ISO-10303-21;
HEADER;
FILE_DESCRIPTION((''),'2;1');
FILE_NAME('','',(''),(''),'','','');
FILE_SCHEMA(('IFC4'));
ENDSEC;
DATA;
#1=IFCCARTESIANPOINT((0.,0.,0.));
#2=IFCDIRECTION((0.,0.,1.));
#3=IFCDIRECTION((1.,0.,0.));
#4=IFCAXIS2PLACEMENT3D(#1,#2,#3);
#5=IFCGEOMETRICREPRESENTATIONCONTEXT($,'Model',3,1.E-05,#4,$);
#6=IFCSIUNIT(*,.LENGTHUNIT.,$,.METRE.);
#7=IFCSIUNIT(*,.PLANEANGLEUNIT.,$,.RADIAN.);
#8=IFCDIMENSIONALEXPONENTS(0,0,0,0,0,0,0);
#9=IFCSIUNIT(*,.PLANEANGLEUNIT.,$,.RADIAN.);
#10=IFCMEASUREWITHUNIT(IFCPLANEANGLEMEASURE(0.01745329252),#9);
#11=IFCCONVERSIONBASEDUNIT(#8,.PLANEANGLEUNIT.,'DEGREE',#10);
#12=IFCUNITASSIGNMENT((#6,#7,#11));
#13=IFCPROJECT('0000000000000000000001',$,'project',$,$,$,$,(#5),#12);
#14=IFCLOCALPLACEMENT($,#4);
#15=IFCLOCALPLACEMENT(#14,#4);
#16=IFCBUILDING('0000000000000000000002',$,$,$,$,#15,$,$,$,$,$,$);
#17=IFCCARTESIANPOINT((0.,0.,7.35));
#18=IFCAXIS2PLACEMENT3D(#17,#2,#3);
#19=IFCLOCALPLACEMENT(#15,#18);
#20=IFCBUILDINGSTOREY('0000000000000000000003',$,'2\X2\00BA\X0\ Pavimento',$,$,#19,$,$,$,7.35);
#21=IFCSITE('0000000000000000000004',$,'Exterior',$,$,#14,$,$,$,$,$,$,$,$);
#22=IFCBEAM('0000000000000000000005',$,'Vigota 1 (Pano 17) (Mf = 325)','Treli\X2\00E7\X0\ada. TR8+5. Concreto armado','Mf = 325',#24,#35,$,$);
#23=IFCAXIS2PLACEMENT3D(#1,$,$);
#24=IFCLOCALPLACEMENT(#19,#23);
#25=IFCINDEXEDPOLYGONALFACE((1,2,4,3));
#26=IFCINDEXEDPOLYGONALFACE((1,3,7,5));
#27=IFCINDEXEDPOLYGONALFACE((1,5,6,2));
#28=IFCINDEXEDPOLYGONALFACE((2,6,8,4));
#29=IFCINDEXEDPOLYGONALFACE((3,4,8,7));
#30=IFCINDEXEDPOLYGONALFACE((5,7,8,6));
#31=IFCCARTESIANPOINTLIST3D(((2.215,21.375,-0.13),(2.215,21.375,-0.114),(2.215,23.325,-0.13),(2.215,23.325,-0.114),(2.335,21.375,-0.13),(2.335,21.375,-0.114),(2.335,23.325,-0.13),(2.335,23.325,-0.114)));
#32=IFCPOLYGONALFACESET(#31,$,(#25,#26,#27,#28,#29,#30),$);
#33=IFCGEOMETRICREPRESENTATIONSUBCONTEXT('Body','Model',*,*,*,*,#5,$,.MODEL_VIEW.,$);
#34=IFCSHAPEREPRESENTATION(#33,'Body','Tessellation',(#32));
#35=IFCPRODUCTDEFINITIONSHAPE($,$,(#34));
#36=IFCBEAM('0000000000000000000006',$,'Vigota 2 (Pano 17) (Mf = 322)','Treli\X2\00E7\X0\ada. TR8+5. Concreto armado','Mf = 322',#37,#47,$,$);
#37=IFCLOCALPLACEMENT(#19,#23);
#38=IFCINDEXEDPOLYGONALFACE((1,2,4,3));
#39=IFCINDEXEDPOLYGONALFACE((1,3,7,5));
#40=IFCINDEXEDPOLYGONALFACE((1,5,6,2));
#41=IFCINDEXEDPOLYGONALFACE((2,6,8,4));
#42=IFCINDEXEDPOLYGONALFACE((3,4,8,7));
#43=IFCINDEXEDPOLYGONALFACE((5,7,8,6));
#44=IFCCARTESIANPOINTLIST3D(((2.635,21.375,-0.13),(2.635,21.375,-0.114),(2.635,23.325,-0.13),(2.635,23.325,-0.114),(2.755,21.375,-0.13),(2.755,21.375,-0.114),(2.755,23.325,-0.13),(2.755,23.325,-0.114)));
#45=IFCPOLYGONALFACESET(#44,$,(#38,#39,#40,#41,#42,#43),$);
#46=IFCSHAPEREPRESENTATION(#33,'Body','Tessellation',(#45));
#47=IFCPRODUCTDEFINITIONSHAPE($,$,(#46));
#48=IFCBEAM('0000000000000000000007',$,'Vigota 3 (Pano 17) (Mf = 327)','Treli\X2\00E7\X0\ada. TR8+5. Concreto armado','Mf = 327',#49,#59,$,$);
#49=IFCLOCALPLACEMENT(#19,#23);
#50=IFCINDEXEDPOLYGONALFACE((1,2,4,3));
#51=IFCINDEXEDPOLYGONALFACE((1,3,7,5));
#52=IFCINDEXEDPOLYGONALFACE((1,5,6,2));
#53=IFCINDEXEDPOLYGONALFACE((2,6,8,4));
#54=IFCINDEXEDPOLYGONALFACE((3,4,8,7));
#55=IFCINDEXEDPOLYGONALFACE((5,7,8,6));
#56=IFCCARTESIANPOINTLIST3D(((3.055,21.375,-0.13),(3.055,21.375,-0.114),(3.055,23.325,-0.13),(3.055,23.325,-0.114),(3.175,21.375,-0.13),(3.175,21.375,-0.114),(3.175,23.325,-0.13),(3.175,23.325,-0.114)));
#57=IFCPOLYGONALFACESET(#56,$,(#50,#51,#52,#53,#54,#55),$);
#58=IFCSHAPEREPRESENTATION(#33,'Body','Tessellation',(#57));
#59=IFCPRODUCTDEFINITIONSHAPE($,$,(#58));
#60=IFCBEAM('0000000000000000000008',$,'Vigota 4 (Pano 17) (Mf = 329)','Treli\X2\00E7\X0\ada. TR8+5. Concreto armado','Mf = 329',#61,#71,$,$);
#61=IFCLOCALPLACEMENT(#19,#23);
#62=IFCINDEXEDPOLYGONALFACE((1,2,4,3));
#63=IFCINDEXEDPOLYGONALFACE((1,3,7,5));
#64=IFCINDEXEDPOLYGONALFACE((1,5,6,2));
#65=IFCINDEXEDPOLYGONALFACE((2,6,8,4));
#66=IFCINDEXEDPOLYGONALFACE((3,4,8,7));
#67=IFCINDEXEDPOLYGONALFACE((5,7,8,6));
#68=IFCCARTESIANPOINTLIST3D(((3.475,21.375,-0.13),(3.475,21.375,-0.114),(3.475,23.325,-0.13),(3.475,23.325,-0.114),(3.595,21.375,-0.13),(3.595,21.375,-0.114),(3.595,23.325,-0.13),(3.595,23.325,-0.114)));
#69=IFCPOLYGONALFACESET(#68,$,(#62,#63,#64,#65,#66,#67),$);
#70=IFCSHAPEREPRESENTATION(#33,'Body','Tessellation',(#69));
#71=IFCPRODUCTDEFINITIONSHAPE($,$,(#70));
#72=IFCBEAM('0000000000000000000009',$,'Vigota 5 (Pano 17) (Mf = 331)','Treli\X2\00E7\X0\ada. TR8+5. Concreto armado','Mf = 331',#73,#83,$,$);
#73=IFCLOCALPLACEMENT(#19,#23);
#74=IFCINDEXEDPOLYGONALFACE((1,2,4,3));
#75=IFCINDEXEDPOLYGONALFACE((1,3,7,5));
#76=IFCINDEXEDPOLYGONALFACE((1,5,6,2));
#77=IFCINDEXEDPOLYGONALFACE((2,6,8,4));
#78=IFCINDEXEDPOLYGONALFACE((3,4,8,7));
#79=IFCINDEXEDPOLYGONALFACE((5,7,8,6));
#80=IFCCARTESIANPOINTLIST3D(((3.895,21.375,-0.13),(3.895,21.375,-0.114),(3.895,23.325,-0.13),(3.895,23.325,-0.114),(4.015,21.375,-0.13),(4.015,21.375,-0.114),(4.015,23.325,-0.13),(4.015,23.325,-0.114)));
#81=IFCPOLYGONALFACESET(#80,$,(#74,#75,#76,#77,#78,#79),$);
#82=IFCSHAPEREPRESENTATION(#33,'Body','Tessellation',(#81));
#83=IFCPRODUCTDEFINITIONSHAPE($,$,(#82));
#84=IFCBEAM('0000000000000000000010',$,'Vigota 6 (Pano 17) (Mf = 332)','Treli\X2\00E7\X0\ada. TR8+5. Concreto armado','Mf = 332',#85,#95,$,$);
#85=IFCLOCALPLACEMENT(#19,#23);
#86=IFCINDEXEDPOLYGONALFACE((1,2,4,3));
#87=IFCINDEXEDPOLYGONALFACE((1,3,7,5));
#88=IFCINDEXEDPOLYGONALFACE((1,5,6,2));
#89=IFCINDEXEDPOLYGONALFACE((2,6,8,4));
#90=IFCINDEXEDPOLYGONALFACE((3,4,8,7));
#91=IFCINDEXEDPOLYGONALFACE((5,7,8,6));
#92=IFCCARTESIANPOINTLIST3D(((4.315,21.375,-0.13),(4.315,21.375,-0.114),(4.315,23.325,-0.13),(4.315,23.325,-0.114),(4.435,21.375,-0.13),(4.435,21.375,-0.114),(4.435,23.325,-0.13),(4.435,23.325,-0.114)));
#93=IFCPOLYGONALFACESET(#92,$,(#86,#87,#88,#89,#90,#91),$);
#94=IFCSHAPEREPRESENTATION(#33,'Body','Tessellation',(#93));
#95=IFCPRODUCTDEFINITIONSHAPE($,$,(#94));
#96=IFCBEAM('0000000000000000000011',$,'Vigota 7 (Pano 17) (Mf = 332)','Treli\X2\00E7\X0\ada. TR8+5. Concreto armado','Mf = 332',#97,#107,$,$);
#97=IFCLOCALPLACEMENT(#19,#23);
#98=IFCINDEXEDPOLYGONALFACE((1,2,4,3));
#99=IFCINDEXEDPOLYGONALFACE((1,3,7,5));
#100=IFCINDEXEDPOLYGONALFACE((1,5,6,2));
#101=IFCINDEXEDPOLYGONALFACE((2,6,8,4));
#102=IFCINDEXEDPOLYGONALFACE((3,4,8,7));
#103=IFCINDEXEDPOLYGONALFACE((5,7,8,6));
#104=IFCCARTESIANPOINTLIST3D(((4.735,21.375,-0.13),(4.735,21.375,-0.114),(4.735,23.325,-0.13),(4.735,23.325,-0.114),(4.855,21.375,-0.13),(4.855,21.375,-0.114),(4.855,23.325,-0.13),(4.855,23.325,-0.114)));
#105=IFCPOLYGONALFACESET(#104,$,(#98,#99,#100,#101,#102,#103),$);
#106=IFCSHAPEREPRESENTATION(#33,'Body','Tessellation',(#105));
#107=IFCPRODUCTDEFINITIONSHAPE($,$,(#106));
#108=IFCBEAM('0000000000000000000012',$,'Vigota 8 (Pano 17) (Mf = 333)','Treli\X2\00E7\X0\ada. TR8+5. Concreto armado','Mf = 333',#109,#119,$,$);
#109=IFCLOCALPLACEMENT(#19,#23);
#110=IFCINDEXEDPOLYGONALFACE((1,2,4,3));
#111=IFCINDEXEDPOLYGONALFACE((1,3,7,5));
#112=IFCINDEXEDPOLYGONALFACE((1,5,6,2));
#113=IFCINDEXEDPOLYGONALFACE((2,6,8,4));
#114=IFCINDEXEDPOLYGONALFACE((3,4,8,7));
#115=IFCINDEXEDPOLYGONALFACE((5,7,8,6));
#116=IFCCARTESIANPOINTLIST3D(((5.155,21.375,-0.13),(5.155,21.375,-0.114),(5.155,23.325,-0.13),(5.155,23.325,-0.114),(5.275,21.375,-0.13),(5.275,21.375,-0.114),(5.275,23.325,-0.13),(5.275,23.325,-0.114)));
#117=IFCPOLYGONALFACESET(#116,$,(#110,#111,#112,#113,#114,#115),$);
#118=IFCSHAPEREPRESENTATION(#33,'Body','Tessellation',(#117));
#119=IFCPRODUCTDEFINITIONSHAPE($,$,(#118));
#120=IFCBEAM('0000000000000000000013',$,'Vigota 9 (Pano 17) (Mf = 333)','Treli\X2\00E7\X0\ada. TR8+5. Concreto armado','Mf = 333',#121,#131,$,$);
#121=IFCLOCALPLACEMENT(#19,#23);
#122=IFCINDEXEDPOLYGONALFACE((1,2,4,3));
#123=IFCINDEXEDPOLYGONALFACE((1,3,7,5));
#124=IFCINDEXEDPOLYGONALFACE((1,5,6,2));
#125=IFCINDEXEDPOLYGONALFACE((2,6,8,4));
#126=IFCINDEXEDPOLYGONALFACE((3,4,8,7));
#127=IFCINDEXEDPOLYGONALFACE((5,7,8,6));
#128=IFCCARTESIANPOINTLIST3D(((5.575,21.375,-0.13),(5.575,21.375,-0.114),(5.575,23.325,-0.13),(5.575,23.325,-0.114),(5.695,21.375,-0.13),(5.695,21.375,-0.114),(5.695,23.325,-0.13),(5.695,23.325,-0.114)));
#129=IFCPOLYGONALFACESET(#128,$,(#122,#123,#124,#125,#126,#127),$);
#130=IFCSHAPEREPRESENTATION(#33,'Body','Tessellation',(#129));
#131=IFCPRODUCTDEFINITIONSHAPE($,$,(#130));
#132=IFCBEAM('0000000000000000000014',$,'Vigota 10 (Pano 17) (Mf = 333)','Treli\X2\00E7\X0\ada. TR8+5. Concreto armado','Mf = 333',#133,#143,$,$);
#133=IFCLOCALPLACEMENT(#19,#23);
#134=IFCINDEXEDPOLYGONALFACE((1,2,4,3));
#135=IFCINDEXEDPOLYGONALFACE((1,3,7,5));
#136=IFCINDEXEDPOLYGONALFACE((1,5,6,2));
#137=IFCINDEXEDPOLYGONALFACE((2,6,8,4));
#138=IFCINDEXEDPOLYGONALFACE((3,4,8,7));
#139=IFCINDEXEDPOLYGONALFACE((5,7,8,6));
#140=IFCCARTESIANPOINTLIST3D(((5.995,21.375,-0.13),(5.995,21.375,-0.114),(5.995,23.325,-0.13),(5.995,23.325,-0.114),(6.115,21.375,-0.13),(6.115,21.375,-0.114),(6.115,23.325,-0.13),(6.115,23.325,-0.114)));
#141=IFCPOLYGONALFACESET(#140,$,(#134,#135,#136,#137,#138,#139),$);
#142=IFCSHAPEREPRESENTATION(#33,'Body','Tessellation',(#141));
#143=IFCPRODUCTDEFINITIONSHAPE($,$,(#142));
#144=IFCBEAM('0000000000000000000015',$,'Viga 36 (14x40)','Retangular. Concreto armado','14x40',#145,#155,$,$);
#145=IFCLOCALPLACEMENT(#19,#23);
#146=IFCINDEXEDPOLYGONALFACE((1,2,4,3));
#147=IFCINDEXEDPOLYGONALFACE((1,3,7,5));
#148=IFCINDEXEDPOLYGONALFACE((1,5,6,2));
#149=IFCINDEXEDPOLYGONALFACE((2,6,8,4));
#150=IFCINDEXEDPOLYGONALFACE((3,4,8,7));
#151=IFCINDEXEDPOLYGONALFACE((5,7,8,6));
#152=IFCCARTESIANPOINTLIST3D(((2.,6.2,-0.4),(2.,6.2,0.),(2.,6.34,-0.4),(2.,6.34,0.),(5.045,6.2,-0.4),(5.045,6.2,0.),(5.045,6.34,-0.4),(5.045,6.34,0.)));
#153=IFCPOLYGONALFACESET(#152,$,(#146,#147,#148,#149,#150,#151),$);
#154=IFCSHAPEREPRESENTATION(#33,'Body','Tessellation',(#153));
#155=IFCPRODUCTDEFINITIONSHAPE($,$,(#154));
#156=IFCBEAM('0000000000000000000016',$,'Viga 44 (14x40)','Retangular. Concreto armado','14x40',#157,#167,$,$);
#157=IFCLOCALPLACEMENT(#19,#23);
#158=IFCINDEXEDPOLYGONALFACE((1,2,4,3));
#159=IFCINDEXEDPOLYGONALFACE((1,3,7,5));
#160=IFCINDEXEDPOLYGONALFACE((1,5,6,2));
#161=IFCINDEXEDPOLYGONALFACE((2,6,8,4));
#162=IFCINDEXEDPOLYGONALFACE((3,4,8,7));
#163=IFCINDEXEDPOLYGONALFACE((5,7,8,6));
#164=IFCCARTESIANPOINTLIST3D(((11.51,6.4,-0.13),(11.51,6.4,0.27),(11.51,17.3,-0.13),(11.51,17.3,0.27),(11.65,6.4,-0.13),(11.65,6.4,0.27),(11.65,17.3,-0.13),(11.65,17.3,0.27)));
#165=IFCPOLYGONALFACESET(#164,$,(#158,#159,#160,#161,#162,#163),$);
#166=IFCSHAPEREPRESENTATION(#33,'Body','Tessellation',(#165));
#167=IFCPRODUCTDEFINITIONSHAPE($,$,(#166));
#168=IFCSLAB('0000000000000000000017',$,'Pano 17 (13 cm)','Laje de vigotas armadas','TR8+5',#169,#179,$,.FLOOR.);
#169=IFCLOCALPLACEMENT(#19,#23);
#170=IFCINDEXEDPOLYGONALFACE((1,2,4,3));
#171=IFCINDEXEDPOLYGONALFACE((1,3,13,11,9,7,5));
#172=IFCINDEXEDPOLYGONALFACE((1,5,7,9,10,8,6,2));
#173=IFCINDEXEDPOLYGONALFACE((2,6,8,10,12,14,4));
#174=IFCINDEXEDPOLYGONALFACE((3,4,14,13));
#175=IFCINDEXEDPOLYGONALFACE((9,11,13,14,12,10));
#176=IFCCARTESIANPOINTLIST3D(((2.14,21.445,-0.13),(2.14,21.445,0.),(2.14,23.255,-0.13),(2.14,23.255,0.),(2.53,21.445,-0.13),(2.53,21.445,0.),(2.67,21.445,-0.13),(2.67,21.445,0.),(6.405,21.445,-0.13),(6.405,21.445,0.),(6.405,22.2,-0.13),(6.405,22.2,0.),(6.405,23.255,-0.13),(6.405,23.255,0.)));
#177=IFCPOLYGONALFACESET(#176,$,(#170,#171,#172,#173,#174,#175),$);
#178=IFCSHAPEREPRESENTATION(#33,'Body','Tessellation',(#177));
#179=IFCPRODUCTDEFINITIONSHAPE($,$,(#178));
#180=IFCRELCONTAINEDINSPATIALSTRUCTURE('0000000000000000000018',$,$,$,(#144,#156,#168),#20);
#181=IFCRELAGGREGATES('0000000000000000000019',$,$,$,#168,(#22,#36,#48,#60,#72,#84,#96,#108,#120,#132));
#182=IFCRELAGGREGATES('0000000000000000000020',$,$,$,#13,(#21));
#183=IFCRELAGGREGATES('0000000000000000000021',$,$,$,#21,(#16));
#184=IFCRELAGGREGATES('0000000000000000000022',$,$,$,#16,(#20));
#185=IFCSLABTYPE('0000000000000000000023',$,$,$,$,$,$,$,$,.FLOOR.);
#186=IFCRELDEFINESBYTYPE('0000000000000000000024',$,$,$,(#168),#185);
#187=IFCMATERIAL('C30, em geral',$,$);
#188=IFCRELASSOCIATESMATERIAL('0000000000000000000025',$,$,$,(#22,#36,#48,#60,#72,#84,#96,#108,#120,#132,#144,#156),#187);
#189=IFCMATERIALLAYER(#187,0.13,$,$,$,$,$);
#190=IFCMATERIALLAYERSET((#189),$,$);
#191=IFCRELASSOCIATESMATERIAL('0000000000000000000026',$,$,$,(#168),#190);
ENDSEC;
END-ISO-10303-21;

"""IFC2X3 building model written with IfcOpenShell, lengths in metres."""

from ifc_helpers import new_model, entity, si_unit, converted_unit, frame, frame_2d, origin_with_axes, place, context, subcontext, project, spatial, polyline, rectangle, outline, extrude, material, layer, layer_set, layer_usage, type_object, element, aggregate, save


model = new_model("IFC2X3")

# Units and contexts
model_context = context("Model", 3, precision=1e-05, world=origin_with_axes())
body_context = subcontext(model_context, "Body", "Model", "MODEL_VIEW")
ifc_project = project(units=[si_unit("LENGTHUNIT", "METRE"), si_unit("PLANEANGLEUNIT", "RADIAN"), converted_unit("PLANEANGLEUNIT", "DEGREE", entity("IfcPlaneAngleMeasure", 0.01745329252), si_unit("PLANEANGLEUNIT", "RADIAN"), dimensions=[0, 0, 0, 0, 0, 0, 0])], contexts=[model_context])

# Beams
ifc_material = material(Name="C30, em geral")
site_placement = place(None, origin_with_axes())
building_placement = place(site_placement, origin_with_axes())
storey_placement = place(building_placement, frame((0.0, 0.0, 7.35), z_axis=(0.0, 0.0, 1.0), x_axis=(1.0, 0.0, 0.0)))
beam_1_placement = place(storey_placement, frame((2.275, 21.375, -0.122), z_axis=(0.0, 1.0, 0.0), x_axis=(-1.0, 0.0, 0.0)))
beam_1 = element("IfcBeam", 1, at=beam_1_placement, material=ifc_material, Name="Vigota 1 (Pano 17) (Mf = 325)", Description="Treliçada. TR8+5. Concreto armado", ObjectType="Mf = 325", context=body_context, shape_type="SweptSolid", body=[
    extrude(outline(polyline([(0.06, 0.008), (-0.06, 0.008), (-0.06, -0.008), (0.06, -0.008), (0.06, 0.008)])), origin_with_axes(), (0.0, 0.0, 1.0), 1.95),
])
beam_2_placement = place(storey_placement, frame((2.695, 21.375, -0.122), z_axis=(0.0, 1.0, 0.0), x_axis=(-1.0, 0.0, 0.0)))
beam_2 = element("IfcBeam", 2, at=beam_2_placement, material=ifc_material, Name="Vigota 2 (Pano 17) (Mf = 322)", Description="Treliçada. TR8+5. Concreto armado", ObjectType="Mf = 322", context=body_context, shape_type="SweptSolid", body=[
    extrude(outline(polyline([(0.06, 0.008), (-0.06, 0.008), (-0.06, -0.008), (0.06, -0.008), (0.06, 0.008)])), origin_with_axes(), (0.0, 0.0, 1.0), 1.95),
])
beam_3_placement = place(storey_placement, frame((3.115, 21.375, -0.122), z_axis=(0.0, 1.0, 0.0), x_axis=(-1.0, 0.0, 0.0)))
beam_3 = element("IfcBeam", 3, at=beam_3_placement, material=ifc_material, Name="Vigota 3 (Pano 17) (Mf = 327)", Description="Treliçada. TR8+5. Concreto armado", ObjectType="Mf = 327", context=body_context, shape_type="SweptSolid", body=[
    extrude(outline(polyline([(0.06, 0.008), (-0.06, 0.008), (-0.06, -0.008), (0.06, -0.008), (0.06, 0.008)])), origin_with_axes(), (0.0, 0.0, 1.0), 1.95),
])
beam_4_placement = place(storey_placement, frame((3.535, 21.375, -0.122), z_axis=(0.0, 1.0, 0.0), x_axis=(-1.0, 0.0, 0.0)))
beam_4 = element("IfcBeam", 4, at=beam_4_placement, material=ifc_material, Name="Vigota 4 (Pano 17) (Mf = 329)", Description="Treliçada. TR8+5. Concreto armado", ObjectType="Mf = 329", context=body_context, shape_type="SweptSolid", body=[
    extrude(outline(polyline([(0.06, 0.008), (-0.06, 0.008), (-0.06, -0.008), (0.06, -0.008), (0.06, 0.008)])), origin_with_axes(), (0.0, 0.0, 1.0), 1.95),
])
beam_5_placement = place(storey_placement, frame((3.955, 21.375, -0.122), z_axis=(0.0, 1.0, 0.0), x_axis=(-1.0, 0.0, 0.0)))
beam_5 = element("IfcBeam", 5, at=beam_5_placement, material=ifc_material, Name="Vigota 5 (Pano 17) (Mf = 331)", Description="Treliçada. TR8+5. Concreto armado", ObjectType="Mf = 331", context=body_context, shape_type="SweptSolid", body=[
    extrude(outline(polyline([(0.06, 0.008), (-0.06, 0.008), (-0.06, -0.008), (0.06, -0.008), (0.06, 0.008)])), origin_with_axes(), (0.0, 0.0, 1.0), 1.95),
])
beam_6_placement = place(storey_placement, frame((4.375, 21.375, -0.122), z_axis=(0.0, 1.0, 0.0), x_axis=(-1.0, 0.0, 0.0)))
beam_6 = element("IfcBeam", 6, at=beam_6_placement, material=ifc_material, Name="Vigota 6 (Pano 17) (Mf = 332)", Description="Treliçada. TR8+5. Concreto armado", ObjectType="Mf = 332", context=body_context, shape_type="SweptSolid", body=[
    extrude(outline(polyline([(0.06, 0.008), (-0.06, 0.008), (-0.06, -0.008), (0.06, -0.008), (0.06, 0.008)])), origin_with_axes(), (0.0, 0.0, 1.0), 1.95),
])
beam_7_placement = place(storey_placement, frame((4.795, 21.375, -0.122), z_axis=(0.0, 1.0, 0.0), x_axis=(-1.0, 0.0, 0.0)))
beam_7 = element("IfcBeam", 7, at=beam_7_placement, material=ifc_material, Name="Vigota 7 (Pano 17) (Mf = 332)", Description="Treliçada. TR8+5. Concreto armado", ObjectType="Mf = 332", context=body_context, shape_type="SweptSolid", body=[
    extrude(outline(polyline([(0.06, 0.008), (-0.06, 0.008), (-0.06, -0.008), (0.06, -0.008), (0.06, 0.008)])), origin_with_axes(), (0.0, 0.0, 1.0), 1.95),
])
beam_8_placement = place(storey_placement, frame((5.215, 21.375, -0.122), z_axis=(0.0, 1.0, 0.0), x_axis=(-1.0, 0.0, 0.0)))
beam_8 = element("IfcBeam", 8, at=beam_8_placement, material=ifc_material, Name="Vigota 8 (Pano 17) (Mf = 333)", Description="Treliçada. TR8+5. Concreto armado", ObjectType="Mf = 333", context=body_context, shape_type="SweptSolid", body=[
    extrude(outline(polyline([(0.06, 0.008), (-0.06, 0.008), (-0.06, -0.008), (0.06, -0.008), (0.06, 0.008)])), origin_with_axes(), (0.0, 0.0, 1.0), 1.95),
])
beam_9_placement = place(storey_placement, frame((5.635, 21.375, -0.122), z_axis=(0.0, 1.0, 0.0), x_axis=(-1.0, 0.0, 0.0)))
beam_9 = element("IfcBeam", 9, at=beam_9_placement, material=ifc_material, Name="Vigota 9 (Pano 17) (Mf = 333)", Description="Treliçada. TR8+5. Concreto armado", ObjectType="Mf = 333", context=body_context, shape_type="SweptSolid", body=[
    extrude(outline(polyline([(0.06, 0.008), (-0.06, 0.008), (-0.06, -0.008), (0.06, -0.008), (0.06, 0.008)])), origin_with_axes(), (0.0, 0.0, 1.0), 1.95),
])
beam_10_placement = place(storey_placement, frame((6.055, 21.375, -0.122), z_axis=(0.0, 1.0, 0.0), x_axis=(-1.0, 0.0, 0.0)))
beam_10 = element("IfcBeam", 10, at=beam_10_placement, material=ifc_material, Name="Vigota 10 (Pano 17) (Mf = 333)", Description="Treliçada. TR8+5. Concreto armado", ObjectType="Mf = 333", context=body_context, shape_type="SweptSolid", body=[
    extrude(outline(polyline([(0.06, 0.008), (-0.06, 0.008), (-0.06, -0.008), (0.06, -0.008), (0.06, 0.008)])), origin_with_axes(), (0.0, 0.0, 1.0), 1.95),
])

# Site, building, storey
site = spatial("IfcSite", under=ifc_project, at=site_placement, Name="Exterior")
building = spatial("IfcBuilding", under=site, at=building_placement)
storey = spatial("IfcBuildingStorey", under=building, at=storey_placement, Name="2º Pavimento", Elevation=7.35)

# Beams
beam_11_placement = place(storey_placement, frame((2.0, 6.27, 0.0), z_axis=(1.0, 0.0, 0.0), x_axis=(0.0, 1.0, 0.0)))
element("IfcBeam", 11, at=beam_11_placement, inside=storey, material=ifc_material, Name="Viga 36 (14x40)", Description="Retangular. Concreto armado", ObjectType="14x40", context=body_context, shape_type="SweptSolid", body=[
    extrude(rectangle(XDim=0.14, YDim=0.4, at=frame_2d((0.0, -0.2), x_axis=(1.0, 0.0))), origin_with_axes(), (0.0, 0.0, 1.0), 3.045),
])
beam_12_placement = place(storey_placement, frame((11.58, 6.4, 0.27), z_axis=(0.0, 1.0, 0.0), x_axis=(-1.0, 0.0, 0.0)))
element("IfcBeam", 12, at=beam_12_placement, inside=storey, material=ifc_material, Name="Viga 44 (14x40)", Description="Retangular. Concreto armado", ObjectType="14x40", context=body_context, shape_type="SweptSolid", body=[
    extrude(rectangle(XDim=0.14, YDim=0.4, at=frame_2d((0.0, -0.2), x_axis=(1.0, 0.0))), origin_with_axes(), (0.0, 0.0, 1.0), 10.9),
])

# Slab
slab_type = type_object("IfcSlabType", PredefinedType="FLOOR")
ifc_layer_1 = layer(ifc_material, 0.13)
ifc_layer_set_1 = layer_set([ifc_layer_1])
ifc_layer_usage_1 = layer_usage(ifc_layer_set_1, "AXIS3", "POSITIVE", 0.0)
slab_1_placement = place(storey_placement, frame((0.0, 0.0, -0.13), z_axis=(0.0, 0.0, 1.0), x_axis=(1.0, 0.0, 0.0)))
slab_1 = element("IfcSlab", 13, at=slab_1_placement, inside=storey, type_object=slab_type, material=ifc_layer_usage_1, Name="Pano 17 (13 cm)", Description="Laje de vigotas armadas", ObjectType="TR8+5", PredefinedType="FLOOR", context=body_context, shape_type="SweptSolid", body=[
    extrude(outline(polyline([(6.405, 23.255), (2.14, 23.255), (2.14, 21.445), (2.53, 21.445), (2.67, 21.445), (6.405, 21.445), (6.405, 22.2), (6.405, 23.255)])), origin_with_axes(), (0.0, 0.0, 1.0), 0.13),
])
aggregate(slab_1, [beam_1, beam_2, beam_3, beam_4, beam_5, beam_6, beam_7, beam_8, beam_9, beam_10])

save(model, "model.ifc")
